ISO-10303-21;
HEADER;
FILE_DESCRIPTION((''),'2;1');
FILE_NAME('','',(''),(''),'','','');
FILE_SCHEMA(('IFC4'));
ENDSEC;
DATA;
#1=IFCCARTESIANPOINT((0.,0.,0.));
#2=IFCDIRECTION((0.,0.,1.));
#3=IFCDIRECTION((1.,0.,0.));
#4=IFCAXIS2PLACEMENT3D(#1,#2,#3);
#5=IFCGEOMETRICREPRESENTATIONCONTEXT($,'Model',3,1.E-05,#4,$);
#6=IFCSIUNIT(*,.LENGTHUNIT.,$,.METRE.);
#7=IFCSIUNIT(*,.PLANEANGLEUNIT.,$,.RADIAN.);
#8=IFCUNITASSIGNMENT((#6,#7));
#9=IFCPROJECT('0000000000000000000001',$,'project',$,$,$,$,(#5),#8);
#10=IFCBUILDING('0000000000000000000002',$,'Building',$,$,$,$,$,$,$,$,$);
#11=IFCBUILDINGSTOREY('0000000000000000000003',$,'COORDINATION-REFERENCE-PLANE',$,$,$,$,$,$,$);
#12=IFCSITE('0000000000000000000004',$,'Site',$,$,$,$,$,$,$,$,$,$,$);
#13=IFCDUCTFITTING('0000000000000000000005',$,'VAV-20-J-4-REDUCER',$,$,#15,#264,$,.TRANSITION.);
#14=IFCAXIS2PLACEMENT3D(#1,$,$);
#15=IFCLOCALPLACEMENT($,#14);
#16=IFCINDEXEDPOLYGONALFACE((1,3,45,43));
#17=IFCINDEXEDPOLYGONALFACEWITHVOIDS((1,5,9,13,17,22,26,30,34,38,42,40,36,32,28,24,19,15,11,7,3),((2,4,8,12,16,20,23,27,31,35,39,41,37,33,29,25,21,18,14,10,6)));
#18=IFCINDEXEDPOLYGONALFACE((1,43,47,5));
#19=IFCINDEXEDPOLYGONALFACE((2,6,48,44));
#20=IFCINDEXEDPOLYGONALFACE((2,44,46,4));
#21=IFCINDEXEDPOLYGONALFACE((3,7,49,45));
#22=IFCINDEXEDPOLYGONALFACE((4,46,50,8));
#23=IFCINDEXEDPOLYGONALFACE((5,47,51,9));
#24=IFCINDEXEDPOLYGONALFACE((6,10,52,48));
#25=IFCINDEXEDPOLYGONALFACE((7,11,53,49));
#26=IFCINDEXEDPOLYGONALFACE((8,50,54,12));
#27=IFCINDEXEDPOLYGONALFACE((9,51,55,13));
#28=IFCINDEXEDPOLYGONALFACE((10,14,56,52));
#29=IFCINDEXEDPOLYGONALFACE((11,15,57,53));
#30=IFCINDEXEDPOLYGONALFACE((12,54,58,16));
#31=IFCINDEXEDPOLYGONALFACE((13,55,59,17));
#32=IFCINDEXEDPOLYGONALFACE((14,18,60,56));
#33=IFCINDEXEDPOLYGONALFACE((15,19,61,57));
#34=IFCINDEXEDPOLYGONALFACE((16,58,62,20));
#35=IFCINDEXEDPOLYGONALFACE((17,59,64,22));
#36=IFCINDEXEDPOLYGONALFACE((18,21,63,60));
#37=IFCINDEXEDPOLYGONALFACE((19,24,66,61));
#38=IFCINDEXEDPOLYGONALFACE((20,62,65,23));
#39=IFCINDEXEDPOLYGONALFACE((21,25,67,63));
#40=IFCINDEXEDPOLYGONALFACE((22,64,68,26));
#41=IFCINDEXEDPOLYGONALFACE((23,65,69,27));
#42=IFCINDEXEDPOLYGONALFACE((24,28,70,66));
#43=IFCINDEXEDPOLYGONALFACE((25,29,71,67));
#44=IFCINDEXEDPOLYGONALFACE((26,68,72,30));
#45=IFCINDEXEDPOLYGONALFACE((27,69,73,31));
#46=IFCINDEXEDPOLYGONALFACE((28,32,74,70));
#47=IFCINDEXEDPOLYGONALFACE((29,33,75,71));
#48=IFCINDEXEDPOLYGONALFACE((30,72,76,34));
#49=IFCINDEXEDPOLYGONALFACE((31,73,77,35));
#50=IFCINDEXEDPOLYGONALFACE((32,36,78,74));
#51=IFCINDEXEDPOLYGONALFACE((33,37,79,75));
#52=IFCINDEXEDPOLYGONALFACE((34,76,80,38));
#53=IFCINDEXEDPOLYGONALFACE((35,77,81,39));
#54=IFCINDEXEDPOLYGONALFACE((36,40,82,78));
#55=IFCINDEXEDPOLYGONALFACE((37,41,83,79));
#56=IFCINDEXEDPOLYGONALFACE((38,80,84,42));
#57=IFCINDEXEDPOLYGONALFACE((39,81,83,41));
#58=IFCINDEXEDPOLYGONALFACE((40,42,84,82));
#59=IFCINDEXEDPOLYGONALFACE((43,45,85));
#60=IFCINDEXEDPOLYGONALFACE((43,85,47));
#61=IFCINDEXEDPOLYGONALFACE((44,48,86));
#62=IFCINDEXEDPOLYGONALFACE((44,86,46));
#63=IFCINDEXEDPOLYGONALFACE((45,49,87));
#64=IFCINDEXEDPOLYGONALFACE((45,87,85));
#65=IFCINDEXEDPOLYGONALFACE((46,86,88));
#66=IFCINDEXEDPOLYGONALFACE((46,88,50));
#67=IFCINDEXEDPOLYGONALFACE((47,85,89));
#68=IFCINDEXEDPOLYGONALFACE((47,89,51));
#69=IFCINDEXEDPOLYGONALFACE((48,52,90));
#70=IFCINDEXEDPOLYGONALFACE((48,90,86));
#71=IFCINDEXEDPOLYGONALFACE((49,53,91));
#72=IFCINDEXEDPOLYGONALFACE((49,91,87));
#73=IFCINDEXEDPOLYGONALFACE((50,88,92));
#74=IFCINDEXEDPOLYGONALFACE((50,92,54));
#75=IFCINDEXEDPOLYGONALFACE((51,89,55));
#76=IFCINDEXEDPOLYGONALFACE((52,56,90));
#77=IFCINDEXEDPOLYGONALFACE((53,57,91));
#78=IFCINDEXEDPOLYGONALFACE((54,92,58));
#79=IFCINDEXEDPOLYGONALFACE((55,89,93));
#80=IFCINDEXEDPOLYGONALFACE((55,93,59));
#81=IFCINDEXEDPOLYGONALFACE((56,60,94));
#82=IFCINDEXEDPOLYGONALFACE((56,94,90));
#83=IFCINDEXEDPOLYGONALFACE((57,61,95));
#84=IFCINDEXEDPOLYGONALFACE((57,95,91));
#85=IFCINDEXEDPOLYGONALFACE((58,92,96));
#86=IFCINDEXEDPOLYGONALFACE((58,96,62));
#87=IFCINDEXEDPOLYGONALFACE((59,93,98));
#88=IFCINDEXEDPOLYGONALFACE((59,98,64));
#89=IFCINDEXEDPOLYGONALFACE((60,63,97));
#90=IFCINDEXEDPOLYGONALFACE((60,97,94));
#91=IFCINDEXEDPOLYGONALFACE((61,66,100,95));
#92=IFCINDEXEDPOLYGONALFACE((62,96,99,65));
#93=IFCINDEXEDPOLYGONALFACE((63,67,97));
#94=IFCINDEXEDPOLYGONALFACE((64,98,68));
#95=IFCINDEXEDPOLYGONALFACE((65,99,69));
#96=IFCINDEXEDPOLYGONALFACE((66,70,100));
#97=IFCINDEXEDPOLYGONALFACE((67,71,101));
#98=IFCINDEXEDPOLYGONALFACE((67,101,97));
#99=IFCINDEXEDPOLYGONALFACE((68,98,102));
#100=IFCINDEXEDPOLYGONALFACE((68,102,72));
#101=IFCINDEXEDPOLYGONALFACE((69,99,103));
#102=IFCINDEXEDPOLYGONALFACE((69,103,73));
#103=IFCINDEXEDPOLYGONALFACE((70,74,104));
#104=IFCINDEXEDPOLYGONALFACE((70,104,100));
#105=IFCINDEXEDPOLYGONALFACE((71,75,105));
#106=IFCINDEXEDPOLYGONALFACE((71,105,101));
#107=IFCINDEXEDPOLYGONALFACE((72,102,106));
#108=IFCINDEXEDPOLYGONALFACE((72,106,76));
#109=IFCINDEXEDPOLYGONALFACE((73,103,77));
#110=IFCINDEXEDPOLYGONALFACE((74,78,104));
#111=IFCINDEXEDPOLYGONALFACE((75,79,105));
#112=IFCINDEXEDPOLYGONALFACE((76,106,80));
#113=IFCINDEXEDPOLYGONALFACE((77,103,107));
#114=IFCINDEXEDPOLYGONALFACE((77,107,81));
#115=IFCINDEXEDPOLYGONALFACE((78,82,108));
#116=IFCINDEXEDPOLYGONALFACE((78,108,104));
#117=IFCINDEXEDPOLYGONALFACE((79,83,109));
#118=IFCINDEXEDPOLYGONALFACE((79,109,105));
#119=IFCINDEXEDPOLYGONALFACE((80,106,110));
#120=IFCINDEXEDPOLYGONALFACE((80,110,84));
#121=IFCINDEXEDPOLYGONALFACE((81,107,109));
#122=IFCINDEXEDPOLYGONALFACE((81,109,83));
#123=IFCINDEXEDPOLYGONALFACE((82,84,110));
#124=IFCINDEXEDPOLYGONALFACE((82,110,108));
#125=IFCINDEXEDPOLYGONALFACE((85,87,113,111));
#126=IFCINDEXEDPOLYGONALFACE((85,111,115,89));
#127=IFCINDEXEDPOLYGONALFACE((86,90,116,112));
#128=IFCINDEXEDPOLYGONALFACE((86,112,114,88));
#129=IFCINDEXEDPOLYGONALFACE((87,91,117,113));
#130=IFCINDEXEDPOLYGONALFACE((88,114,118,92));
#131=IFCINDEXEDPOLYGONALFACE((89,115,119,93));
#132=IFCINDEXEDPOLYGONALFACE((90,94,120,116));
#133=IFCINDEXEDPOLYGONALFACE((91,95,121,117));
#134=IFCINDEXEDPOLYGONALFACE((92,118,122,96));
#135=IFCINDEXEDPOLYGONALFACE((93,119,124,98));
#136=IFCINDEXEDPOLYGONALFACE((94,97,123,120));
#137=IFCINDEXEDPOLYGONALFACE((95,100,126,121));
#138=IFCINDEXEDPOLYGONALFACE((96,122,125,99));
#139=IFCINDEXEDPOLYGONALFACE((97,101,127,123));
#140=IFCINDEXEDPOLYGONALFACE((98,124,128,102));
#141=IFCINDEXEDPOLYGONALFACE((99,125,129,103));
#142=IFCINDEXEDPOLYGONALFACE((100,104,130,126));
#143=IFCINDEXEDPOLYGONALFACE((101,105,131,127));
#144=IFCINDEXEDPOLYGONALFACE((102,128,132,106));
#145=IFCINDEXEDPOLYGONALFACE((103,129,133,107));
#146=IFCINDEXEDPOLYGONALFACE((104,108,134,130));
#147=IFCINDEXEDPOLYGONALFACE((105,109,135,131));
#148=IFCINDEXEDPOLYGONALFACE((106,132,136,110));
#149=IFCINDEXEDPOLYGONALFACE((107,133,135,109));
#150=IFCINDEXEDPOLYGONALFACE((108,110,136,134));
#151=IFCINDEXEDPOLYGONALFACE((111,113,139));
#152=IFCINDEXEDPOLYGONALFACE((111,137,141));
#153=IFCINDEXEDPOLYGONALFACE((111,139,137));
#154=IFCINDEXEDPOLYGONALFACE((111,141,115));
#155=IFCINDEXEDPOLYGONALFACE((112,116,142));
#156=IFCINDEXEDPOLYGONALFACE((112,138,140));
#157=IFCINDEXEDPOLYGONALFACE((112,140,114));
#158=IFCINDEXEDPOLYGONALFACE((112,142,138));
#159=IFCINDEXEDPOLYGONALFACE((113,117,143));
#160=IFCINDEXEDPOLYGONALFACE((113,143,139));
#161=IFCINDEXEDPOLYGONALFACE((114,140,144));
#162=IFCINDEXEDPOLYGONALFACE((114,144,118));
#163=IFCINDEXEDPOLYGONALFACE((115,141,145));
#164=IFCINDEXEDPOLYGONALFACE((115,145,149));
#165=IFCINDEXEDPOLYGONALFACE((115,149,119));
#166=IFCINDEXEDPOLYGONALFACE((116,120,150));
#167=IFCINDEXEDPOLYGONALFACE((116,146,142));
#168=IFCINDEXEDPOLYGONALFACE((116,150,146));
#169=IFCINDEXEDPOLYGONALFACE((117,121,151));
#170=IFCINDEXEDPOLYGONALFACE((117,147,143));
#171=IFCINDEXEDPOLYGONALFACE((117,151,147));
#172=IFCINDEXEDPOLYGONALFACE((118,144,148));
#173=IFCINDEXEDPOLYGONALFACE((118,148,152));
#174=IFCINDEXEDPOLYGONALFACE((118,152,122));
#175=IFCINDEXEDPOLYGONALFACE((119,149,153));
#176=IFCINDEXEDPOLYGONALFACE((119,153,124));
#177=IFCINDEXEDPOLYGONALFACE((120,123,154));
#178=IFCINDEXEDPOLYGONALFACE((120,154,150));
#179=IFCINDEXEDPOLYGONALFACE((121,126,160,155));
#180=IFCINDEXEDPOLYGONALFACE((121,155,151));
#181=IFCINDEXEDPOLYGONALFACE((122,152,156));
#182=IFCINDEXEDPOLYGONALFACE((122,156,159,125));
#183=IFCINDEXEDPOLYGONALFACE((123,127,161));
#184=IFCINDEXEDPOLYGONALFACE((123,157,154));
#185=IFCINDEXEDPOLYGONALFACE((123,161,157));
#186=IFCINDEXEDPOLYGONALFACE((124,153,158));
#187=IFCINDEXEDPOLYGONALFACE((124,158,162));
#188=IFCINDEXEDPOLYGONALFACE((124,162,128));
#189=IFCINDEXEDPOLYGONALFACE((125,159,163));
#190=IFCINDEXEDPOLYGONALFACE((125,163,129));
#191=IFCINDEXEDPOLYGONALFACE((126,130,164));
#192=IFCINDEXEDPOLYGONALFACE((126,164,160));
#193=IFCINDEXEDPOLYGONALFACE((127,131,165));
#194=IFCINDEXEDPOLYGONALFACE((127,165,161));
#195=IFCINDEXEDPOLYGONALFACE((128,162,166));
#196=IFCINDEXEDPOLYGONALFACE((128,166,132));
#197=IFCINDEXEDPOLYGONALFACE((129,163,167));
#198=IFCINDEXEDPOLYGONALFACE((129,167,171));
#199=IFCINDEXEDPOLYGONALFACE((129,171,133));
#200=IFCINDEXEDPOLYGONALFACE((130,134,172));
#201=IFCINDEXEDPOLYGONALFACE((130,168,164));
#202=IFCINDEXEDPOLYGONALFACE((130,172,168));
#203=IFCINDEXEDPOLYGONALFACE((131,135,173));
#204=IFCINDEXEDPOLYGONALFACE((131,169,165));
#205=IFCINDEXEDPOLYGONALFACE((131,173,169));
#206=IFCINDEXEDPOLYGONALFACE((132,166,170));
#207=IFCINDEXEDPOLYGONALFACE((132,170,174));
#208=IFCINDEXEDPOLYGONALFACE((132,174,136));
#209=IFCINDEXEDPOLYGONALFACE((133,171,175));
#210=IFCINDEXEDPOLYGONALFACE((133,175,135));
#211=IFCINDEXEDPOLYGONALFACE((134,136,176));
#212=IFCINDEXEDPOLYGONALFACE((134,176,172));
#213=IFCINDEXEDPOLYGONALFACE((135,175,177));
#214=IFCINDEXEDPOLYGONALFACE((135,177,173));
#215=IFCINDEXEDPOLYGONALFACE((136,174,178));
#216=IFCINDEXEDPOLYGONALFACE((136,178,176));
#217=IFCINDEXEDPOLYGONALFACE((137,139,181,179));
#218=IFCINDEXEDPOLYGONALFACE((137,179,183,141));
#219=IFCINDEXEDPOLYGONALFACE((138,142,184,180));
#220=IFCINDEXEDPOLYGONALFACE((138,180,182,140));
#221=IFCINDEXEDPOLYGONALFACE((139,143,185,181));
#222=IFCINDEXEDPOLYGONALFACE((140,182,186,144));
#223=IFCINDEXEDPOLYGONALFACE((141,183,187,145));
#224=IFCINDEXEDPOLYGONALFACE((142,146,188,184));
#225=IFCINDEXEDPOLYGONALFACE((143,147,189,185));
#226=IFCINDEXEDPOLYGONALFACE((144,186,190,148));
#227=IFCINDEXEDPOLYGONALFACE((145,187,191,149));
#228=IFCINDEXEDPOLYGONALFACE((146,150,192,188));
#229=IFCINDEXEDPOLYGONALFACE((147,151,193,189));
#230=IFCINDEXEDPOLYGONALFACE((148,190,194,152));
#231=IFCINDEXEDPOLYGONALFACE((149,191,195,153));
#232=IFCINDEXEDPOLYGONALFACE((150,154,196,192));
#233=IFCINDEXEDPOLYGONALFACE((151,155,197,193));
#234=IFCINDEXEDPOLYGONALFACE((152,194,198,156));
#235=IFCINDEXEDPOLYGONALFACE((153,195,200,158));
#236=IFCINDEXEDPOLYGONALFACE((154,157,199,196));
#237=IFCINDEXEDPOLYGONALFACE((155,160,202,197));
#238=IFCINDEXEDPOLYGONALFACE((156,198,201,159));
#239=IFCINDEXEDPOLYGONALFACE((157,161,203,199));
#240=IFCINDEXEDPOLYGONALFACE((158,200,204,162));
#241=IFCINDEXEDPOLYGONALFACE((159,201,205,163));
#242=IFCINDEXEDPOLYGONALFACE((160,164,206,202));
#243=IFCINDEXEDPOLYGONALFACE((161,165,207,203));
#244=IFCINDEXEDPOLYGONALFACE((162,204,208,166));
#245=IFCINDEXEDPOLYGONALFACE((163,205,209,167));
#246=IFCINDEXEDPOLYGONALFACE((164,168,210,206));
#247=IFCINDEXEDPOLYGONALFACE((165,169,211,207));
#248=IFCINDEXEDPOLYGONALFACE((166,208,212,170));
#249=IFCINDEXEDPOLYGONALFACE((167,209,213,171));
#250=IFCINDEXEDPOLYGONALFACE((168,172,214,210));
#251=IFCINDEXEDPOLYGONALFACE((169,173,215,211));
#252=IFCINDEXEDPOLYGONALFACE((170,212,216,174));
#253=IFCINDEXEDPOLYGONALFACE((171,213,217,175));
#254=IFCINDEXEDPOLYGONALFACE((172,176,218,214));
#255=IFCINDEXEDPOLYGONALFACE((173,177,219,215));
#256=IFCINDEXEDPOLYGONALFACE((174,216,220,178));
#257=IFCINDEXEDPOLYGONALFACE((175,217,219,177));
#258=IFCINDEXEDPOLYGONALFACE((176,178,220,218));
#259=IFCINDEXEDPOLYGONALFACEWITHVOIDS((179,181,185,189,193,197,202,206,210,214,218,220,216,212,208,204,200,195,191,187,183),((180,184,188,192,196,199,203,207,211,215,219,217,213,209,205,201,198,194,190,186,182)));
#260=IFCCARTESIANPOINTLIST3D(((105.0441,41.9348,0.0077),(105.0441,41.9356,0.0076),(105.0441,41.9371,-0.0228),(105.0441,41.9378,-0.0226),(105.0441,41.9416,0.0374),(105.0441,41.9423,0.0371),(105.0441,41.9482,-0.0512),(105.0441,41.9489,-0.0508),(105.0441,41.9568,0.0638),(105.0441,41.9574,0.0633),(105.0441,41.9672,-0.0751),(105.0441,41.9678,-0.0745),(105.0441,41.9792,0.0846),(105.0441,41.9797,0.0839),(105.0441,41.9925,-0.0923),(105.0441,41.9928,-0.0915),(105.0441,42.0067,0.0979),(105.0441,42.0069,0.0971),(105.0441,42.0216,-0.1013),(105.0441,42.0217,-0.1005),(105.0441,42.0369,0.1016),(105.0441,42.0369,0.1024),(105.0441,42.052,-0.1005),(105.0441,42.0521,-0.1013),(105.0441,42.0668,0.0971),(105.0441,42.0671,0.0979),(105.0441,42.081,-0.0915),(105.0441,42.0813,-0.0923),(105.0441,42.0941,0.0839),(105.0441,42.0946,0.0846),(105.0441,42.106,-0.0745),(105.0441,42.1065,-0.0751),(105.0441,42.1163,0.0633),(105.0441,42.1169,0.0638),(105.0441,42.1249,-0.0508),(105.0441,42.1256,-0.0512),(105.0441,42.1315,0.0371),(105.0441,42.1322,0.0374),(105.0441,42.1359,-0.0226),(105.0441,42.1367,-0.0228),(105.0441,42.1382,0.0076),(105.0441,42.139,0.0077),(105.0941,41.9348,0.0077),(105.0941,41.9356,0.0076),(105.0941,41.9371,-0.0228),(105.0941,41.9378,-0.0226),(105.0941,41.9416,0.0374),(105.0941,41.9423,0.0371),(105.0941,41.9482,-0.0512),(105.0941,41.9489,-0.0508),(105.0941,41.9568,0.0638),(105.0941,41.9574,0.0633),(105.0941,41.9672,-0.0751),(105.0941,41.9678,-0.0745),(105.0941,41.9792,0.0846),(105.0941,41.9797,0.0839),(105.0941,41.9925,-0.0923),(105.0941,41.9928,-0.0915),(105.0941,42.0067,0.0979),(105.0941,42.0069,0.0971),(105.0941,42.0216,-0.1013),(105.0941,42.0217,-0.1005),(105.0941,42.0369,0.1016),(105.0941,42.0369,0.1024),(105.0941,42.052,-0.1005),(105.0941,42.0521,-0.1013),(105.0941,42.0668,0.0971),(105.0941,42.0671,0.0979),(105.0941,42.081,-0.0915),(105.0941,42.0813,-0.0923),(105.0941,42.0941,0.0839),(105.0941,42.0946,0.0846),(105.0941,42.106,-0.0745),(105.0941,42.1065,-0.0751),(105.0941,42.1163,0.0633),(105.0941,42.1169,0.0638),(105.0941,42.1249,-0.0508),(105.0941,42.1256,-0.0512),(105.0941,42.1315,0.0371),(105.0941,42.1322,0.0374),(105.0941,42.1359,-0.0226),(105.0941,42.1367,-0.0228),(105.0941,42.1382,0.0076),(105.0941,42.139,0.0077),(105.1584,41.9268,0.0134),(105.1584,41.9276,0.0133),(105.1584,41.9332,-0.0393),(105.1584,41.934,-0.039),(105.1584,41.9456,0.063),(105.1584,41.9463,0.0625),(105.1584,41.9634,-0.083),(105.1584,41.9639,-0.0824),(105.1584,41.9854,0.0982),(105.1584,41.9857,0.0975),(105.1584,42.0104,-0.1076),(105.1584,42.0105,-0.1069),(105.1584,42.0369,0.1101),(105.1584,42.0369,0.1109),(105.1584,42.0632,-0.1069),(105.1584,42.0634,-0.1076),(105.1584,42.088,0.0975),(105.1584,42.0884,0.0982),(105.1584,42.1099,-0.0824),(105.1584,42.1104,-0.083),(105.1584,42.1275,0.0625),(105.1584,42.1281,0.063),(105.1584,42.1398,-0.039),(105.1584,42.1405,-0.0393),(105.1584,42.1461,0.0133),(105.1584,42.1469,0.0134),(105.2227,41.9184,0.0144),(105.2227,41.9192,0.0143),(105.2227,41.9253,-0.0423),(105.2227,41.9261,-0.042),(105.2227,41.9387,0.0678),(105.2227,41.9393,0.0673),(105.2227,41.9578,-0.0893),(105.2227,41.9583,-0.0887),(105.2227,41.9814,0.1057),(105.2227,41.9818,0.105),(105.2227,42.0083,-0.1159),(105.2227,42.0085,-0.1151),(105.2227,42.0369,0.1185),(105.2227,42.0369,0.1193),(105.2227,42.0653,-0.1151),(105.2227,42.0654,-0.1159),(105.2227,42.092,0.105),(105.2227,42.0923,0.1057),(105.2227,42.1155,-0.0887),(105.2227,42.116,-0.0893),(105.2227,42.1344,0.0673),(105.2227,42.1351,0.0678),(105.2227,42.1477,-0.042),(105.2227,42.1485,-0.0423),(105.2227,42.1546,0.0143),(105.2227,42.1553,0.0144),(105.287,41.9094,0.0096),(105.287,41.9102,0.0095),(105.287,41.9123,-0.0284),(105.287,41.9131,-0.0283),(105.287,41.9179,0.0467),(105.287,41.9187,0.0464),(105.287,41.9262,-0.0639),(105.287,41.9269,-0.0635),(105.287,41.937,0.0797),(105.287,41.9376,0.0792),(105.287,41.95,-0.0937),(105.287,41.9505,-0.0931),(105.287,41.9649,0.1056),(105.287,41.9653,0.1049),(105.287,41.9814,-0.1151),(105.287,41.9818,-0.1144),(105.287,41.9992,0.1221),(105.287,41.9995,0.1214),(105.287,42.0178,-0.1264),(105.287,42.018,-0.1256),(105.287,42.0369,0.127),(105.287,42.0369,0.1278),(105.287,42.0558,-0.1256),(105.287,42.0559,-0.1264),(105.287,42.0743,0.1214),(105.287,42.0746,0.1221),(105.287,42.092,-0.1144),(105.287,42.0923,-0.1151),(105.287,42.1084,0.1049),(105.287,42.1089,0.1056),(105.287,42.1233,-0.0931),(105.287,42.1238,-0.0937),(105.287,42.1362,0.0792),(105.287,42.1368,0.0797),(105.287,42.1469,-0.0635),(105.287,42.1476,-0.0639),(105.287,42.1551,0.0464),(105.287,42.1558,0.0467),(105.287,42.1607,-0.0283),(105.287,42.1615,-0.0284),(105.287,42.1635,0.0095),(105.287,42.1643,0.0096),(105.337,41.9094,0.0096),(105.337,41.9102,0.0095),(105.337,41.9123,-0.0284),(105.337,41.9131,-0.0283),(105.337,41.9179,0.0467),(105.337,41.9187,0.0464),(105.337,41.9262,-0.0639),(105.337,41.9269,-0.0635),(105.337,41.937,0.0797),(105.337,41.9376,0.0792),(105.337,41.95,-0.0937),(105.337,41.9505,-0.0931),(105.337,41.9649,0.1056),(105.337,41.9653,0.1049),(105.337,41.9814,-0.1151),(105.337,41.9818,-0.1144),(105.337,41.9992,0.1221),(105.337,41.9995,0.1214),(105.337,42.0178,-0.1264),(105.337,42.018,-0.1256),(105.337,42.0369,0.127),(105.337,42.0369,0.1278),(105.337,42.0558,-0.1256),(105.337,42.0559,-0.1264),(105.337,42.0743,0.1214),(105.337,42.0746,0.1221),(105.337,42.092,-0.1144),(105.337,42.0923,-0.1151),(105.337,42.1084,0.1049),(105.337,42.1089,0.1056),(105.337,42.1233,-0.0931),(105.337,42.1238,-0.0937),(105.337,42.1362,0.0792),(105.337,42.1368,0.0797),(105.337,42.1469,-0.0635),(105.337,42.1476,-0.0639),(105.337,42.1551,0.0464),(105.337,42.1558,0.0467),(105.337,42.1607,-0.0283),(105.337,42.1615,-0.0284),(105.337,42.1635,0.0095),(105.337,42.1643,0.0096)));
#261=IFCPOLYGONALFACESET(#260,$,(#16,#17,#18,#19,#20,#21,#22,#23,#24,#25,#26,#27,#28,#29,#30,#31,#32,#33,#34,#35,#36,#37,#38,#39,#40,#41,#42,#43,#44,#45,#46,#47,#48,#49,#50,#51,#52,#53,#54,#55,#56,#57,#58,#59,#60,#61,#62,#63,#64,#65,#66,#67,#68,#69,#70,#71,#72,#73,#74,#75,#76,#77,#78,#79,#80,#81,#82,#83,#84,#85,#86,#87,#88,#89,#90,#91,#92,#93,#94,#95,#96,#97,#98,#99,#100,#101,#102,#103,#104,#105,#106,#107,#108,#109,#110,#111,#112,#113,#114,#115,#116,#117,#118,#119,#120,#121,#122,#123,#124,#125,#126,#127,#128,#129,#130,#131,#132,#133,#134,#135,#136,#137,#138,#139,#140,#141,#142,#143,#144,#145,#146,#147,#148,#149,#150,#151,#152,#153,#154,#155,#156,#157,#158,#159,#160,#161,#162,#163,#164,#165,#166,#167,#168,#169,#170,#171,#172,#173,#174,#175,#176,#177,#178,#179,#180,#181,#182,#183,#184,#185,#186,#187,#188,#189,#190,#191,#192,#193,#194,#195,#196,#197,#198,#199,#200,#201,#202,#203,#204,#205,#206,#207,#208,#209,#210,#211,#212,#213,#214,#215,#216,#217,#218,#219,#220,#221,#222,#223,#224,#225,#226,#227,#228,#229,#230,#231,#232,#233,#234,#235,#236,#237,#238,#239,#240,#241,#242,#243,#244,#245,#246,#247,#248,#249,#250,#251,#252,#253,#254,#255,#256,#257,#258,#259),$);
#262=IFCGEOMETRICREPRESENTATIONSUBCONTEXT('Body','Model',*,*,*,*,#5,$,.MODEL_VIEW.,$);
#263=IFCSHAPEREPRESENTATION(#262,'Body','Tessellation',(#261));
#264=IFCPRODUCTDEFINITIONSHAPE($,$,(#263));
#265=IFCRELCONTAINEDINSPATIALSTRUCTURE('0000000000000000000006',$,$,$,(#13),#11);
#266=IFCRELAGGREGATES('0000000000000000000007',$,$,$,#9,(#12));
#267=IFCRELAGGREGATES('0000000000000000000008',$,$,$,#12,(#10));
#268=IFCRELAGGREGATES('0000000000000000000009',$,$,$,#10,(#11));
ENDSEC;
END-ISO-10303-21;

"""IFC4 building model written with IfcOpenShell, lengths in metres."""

from ifc_helpers import new_model, entity, si_unit, frame, origin_with_axes, place, context, subcontext, project, spatial, element, save


model = new_model("IFC4")

# Units and contexts
model_context = context("Model", 3, precision=1e-05, world=origin_with_axes())
body_context_1 = subcontext(model_context, "Body", "Model", "MODEL_VIEW")
ifc_project = project(units=[si_unit("LENGTHUNIT", "METRE"), si_unit("PLANEANGLEUNIT", "RADIAN")], contexts=[model_context])

# Site, building, storey
site = spatial("IfcSite", under=ifc_project, Name="Site")
building = spatial("IfcBuilding", under=site, Name="Building")
storey = spatial("IfcBuildingStorey", under=building, Name="COORDINATION-REFERENCE-PLANE")

# Duct fitting
for number, where, z_axis, x_axis, name in (
    (1, (105.337, 42.0369, 0.0), (0.0, -1.0, 0.0), (0.0, 0.0, 1.0), "VAV-20-J-4-REDUCER"),
):
    element("IfcDuctFitting", number, at=place(None, frame(where, z_axis=z_axis, x_axis=x_axis)), inside=storey, Name=name, PredefinedType="TRANSITION", context=body_context_1, shape_type="SweptSolid", body=[
        entity("IfcRevolvedAreaSolid", entity("IfcArbitraryClosedProfileDef", "AREA", None, entity("IfcPolyline", [entity("IfcCartesianPoint", [0.1278, 0.0]), entity("IfcCartesianPoint", [0.1278, 0.05]), entity("IfcCartesianPoint", [0.1024, 0.2429]), entity("IfcCartesianPoint", [0.1024, 0.2929]), entity("IfcCartesianPoint", [0.1016, 0.2929]), entity("IfcCartesianPoint", [0.1016, 0.2429]), entity("IfcCartesianPoint", [0.127, 0.05]), entity("IfcCartesianPoint", [0.127, 0.0]), entity("IfcCartesianPoint", [0.1278, 0.0])])), entity("IfcAxis2Placement3D", entity("IfcCartesianPoint", [0.0, 0.0, 0.0])), entity("IfcAxis1Placement", entity("IfcCartesianPoint", [0.0, 0.0, 0.0]), entity("IfcDirection", [0.0, 1.0, 0.0])), 6.283185),
    ])

save(model, "model.ifc")
